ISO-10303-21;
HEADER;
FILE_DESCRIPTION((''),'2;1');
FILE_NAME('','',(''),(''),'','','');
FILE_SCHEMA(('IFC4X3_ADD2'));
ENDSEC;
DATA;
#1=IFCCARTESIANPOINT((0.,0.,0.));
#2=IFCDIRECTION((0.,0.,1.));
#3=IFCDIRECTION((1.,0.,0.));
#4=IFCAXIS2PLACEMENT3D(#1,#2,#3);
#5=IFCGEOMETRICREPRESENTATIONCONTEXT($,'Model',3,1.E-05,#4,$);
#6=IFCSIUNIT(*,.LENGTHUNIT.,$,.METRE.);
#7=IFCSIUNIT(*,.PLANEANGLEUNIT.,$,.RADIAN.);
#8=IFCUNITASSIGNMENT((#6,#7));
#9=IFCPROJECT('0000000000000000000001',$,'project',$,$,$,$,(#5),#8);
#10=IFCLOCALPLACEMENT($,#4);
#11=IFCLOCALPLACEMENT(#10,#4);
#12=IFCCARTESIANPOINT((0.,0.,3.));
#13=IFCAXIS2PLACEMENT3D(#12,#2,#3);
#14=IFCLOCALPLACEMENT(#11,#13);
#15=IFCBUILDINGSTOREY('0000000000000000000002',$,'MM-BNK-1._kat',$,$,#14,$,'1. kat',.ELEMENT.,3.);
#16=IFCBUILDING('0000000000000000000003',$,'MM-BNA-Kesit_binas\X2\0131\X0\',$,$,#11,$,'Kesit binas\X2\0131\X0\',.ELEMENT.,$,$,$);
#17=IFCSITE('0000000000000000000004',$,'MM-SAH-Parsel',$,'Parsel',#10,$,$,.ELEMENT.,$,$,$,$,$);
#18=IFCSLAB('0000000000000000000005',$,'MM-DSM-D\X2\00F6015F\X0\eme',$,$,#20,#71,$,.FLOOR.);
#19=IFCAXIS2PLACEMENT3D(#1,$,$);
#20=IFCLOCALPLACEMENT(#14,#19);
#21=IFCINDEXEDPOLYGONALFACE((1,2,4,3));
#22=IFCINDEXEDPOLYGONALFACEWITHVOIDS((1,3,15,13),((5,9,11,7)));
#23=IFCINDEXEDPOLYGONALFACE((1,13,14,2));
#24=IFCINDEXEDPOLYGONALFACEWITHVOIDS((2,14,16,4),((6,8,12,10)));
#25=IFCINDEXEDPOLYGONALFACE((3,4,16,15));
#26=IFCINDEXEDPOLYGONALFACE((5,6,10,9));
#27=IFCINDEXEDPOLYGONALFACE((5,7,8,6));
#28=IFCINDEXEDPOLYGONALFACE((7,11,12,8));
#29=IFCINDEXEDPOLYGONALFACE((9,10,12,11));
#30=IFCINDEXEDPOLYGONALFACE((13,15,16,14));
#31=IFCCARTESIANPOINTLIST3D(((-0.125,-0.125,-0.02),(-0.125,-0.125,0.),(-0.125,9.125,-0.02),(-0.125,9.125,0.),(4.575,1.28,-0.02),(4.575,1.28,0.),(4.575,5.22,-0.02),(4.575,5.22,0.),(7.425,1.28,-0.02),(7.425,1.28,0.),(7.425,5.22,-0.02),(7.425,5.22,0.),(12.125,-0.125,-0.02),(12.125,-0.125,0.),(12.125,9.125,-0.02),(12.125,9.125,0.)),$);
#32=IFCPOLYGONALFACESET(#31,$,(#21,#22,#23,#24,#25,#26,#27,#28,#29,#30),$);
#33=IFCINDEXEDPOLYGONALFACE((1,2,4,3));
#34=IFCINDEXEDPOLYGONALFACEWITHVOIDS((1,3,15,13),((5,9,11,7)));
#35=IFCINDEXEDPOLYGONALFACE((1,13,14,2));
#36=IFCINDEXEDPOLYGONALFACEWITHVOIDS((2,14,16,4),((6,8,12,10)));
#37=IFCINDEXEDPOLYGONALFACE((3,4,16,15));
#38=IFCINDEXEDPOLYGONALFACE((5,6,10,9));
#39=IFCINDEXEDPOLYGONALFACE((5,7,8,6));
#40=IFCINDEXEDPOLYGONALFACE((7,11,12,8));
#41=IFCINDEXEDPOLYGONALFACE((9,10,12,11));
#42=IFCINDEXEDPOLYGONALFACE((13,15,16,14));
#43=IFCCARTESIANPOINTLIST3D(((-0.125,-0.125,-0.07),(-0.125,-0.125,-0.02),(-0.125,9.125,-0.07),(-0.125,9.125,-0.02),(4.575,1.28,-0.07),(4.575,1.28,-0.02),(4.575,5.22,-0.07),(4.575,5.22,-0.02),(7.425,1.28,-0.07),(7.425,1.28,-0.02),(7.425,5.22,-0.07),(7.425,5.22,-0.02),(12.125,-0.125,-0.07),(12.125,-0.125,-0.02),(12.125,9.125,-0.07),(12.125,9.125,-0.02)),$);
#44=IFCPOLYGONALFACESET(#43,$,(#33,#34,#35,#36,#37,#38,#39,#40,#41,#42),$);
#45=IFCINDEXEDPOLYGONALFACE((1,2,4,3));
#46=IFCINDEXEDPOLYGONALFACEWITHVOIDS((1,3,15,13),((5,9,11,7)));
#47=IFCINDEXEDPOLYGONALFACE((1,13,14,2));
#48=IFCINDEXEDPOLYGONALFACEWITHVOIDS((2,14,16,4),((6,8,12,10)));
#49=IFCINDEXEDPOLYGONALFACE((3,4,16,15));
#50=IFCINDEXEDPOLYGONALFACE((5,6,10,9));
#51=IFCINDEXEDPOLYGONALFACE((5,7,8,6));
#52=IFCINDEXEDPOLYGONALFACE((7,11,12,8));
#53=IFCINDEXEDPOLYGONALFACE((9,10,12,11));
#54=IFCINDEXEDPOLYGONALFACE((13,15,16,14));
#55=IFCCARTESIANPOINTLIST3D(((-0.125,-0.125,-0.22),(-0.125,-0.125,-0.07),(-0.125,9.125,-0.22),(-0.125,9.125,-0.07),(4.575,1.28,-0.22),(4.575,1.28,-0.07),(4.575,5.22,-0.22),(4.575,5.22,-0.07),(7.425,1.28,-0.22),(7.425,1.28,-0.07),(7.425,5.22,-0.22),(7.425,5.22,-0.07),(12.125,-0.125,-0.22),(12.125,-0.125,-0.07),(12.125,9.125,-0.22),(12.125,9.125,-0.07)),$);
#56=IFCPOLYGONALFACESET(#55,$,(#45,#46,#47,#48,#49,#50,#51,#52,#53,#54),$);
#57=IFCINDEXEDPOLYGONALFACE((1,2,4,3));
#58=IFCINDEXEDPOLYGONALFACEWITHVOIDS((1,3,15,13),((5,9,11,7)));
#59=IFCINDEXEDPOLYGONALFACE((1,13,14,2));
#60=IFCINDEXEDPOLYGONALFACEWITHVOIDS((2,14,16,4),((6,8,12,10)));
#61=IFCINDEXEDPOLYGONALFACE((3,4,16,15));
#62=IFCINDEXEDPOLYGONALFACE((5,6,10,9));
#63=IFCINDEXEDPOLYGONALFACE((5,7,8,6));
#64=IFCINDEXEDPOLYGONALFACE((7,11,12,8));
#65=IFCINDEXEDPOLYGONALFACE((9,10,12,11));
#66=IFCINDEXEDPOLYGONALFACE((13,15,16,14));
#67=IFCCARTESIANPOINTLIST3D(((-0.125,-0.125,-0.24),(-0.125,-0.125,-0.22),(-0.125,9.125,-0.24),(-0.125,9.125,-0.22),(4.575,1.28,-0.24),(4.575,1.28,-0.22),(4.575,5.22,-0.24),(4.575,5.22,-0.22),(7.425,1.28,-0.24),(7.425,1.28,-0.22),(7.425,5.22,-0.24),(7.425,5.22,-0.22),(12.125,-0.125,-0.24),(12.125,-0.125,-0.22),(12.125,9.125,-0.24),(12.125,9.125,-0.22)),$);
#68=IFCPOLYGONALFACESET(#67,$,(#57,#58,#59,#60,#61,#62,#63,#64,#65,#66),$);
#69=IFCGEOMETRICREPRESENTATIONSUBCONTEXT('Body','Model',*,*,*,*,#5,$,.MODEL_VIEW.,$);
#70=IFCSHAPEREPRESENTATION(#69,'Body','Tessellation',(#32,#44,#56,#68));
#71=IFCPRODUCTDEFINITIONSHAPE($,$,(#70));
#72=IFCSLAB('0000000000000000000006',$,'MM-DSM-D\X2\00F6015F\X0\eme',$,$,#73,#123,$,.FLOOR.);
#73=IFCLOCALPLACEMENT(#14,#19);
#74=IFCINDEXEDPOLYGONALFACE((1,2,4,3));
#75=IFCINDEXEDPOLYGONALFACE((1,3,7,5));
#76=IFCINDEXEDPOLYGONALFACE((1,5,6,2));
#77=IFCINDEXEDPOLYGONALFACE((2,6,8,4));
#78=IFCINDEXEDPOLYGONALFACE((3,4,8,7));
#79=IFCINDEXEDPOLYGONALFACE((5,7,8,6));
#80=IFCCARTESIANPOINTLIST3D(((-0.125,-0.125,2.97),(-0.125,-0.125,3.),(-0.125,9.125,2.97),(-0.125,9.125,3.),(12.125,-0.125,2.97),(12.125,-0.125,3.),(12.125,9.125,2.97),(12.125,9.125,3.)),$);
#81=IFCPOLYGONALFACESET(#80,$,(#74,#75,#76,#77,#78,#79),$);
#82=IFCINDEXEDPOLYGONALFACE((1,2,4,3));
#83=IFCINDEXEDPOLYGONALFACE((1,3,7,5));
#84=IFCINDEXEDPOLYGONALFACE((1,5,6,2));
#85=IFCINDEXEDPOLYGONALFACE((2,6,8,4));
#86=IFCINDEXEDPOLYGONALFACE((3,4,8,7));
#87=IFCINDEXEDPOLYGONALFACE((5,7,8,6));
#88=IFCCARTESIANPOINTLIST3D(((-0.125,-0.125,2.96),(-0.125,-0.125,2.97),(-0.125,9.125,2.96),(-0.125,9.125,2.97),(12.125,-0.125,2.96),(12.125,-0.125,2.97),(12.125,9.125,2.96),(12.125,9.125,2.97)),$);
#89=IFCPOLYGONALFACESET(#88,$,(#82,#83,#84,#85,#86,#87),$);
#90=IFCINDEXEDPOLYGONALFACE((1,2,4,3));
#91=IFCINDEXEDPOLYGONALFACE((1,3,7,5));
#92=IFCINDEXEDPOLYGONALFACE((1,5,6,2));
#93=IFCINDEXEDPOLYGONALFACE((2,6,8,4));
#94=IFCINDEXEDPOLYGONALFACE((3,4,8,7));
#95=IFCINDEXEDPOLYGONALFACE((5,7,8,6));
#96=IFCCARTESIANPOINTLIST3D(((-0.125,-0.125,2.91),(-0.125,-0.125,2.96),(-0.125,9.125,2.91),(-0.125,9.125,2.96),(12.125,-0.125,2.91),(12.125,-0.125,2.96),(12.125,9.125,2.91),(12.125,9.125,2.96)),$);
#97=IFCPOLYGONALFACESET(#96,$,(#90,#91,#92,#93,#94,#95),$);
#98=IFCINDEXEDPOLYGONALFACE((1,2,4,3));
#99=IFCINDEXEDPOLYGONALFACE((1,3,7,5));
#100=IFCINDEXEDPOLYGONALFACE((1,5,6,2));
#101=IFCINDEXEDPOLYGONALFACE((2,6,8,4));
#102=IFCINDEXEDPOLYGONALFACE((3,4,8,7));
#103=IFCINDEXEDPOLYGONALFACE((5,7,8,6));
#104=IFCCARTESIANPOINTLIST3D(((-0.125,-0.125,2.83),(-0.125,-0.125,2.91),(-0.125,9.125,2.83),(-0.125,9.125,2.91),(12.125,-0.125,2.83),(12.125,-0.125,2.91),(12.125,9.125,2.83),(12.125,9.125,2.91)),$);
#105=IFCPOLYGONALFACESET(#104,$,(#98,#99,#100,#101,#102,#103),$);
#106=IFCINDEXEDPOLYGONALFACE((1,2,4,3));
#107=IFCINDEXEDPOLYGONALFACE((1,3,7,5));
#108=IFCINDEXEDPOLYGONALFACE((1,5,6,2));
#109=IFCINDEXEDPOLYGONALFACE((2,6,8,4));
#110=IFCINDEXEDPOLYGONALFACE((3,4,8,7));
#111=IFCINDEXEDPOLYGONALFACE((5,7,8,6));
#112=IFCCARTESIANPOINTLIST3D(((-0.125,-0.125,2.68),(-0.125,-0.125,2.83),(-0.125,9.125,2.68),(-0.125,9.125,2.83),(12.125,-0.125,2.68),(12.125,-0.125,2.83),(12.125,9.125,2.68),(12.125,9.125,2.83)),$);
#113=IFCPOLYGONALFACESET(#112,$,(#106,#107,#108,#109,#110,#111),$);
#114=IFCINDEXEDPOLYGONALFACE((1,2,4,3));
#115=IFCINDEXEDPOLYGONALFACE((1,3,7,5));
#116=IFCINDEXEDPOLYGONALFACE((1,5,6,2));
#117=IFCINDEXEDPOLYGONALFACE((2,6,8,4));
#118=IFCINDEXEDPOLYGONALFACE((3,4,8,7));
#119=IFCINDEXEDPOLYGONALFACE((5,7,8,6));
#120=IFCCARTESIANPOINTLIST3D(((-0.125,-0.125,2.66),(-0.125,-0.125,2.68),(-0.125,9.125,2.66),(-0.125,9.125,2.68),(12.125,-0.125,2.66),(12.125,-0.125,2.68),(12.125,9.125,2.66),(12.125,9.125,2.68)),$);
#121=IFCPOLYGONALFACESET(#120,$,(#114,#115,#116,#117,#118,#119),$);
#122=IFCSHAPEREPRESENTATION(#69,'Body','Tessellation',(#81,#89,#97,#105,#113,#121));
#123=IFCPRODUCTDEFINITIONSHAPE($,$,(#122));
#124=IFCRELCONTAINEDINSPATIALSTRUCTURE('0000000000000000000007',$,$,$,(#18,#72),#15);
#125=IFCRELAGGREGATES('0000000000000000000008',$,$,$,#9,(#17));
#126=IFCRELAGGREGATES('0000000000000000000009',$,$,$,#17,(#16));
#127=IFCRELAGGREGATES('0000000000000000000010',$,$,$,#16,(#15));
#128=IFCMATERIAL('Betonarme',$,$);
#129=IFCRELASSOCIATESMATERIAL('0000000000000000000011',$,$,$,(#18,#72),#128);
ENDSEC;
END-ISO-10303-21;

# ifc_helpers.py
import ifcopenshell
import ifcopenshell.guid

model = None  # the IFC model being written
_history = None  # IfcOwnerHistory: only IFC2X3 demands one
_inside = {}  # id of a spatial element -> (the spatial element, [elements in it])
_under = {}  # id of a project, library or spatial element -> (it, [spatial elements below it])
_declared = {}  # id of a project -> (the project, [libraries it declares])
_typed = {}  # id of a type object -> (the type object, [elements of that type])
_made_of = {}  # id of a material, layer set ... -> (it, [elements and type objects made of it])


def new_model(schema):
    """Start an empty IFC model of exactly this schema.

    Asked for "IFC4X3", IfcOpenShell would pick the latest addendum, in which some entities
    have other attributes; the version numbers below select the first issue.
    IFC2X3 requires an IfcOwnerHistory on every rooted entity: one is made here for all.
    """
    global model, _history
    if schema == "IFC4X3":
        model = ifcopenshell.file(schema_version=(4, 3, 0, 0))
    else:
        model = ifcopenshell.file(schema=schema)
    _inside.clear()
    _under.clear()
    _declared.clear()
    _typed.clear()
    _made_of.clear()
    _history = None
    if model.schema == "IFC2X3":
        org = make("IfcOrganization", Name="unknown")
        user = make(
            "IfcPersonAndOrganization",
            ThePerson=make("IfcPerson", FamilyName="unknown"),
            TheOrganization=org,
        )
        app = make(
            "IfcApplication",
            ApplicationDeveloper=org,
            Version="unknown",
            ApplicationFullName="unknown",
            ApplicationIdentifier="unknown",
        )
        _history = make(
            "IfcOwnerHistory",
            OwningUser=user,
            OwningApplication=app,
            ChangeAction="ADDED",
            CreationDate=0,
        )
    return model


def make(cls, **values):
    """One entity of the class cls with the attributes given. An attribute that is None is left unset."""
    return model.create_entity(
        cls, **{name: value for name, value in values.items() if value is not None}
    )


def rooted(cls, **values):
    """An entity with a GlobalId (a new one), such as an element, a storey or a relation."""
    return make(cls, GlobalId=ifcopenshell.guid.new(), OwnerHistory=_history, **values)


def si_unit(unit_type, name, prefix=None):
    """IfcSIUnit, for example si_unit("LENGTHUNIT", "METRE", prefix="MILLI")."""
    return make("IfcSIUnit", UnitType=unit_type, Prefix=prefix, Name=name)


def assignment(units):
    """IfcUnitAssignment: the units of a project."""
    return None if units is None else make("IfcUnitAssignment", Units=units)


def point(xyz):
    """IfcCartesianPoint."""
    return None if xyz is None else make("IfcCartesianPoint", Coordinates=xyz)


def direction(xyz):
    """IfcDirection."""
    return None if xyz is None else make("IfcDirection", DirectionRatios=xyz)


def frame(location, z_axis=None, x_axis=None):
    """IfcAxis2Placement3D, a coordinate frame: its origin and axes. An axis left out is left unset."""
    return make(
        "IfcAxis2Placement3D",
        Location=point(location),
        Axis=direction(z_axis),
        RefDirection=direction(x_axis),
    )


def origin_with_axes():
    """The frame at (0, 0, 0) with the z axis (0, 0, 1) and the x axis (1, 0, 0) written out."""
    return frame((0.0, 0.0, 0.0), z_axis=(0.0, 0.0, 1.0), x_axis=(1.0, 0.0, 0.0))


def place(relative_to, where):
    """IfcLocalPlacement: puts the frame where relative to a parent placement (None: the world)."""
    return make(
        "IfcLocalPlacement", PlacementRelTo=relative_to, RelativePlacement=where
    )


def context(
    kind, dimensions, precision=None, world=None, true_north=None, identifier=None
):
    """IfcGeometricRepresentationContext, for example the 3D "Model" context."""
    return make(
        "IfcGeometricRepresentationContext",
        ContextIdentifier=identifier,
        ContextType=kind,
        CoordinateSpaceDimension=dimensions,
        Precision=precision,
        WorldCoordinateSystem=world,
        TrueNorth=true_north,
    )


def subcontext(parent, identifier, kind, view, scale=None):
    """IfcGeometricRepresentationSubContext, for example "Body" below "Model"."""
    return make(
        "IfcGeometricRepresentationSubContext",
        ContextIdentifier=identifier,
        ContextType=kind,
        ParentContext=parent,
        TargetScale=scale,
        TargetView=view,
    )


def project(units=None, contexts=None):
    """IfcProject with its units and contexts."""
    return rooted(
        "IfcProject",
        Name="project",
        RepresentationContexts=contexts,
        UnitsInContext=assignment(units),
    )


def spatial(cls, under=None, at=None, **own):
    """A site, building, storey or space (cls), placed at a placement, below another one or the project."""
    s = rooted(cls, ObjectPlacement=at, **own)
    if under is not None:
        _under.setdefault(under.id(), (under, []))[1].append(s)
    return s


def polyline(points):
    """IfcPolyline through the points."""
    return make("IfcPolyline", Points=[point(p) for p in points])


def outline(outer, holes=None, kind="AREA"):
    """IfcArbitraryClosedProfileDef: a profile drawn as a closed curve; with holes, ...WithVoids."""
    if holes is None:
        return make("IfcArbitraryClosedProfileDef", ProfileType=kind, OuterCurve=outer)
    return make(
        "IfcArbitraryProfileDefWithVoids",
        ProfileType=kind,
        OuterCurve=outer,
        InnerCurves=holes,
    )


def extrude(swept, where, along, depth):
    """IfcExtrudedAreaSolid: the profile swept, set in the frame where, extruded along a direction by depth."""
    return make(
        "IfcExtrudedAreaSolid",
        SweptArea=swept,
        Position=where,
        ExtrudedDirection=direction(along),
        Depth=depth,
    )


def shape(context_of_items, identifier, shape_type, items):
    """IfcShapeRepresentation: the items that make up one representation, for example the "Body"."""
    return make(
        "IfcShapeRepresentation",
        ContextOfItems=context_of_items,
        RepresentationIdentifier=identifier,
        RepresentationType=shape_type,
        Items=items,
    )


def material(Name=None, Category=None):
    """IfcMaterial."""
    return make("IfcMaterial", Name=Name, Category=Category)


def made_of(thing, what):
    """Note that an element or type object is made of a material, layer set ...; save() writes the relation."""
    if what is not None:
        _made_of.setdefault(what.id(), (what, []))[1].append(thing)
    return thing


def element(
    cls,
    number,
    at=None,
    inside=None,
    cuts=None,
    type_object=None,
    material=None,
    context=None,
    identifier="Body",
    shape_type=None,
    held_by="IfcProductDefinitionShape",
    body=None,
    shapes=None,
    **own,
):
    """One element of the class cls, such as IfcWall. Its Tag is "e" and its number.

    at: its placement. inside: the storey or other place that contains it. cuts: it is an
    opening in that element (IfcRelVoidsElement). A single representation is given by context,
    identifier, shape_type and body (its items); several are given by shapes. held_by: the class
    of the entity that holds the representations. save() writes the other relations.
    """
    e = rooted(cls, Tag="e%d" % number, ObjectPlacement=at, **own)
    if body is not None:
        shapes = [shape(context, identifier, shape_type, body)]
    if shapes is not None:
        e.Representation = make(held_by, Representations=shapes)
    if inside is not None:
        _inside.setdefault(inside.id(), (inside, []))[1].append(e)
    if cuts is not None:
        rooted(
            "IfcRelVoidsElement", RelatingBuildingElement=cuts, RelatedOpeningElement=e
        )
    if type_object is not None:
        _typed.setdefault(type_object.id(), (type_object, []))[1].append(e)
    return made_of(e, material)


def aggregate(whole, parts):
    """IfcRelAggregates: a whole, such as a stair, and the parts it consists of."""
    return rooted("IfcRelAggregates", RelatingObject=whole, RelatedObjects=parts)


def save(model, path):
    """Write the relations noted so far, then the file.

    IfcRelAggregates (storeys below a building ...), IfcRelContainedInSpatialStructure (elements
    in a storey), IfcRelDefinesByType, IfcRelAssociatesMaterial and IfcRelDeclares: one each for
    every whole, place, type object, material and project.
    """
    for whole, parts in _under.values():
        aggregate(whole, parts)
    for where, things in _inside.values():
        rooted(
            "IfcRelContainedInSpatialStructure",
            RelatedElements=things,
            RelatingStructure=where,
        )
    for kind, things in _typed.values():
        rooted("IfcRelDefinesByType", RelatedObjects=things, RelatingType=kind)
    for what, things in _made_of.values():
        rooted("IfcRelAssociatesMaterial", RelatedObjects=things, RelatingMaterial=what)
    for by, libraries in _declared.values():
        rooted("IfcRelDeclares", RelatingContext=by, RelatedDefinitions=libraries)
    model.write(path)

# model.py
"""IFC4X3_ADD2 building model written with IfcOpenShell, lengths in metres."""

from ifc_helpers import new_model, si_unit, frame, origin_with_axes, place, context, subcontext, project, spatial, polyline, outline, extrude, material, element, save


model = new_model("IFC4X3_ADD2")

# Units and contexts
model_context = context("Model", 3, precision=1e-05, world=origin_with_axes())
body_context = subcontext(model_context, "Body", "Model", "MODEL_VIEW")
ifc_project = project(units=[si_unit("LENGTHUNIT", "METRE"), si_unit("PLANEANGLEUNIT", "RADIAN")], contexts=[model_context])

# Site, building, storey
site_placement = place(None, origin_with_axes())
site = spatial("IfcSite", under=ifc_project, at=site_placement, Name="MM-SAH-Parsel", ObjectType="Parsel", CompositionType="ELEMENT")
building_placement = place(site_placement, origin_with_axes())
building = spatial("IfcBuilding", under=site, at=building_placement, Name="MM-BNA-Kesit_binası", LongName="Kesit binası", CompositionType="ELEMENT")
storey_placement = place(building_placement, frame((0.0, 0.0, 3.0), z_axis=(0.0, 0.0, 1.0), x_axis=(1.0, 0.0, 0.0)))
storey = spatial("IfcBuildingStorey", under=building, at=storey_placement, Name="MM-BNK-1._kat", LongName="1. kat", CompositionType="ELEMENT", Elevation=3.0)

# Shared definitions
ifc_material_1 = material(Name="Betonarme")

# Slab, opening
slab_1_placement = place(storey_placement, origin_with_axes())
slab_1 = element("IfcSlab", 1, at=slab_1_placement, inside=storey, material=ifc_material_1, Name="MM-DSM-Döşeme", PredefinedType="FLOOR", context=body_context, shape_type="SweptSolid", body=[
    extrude(outline(polyline([(-0.125, -0.125), (12.125, -0.125), (12.125, 9.125), (-0.125, 9.125), (-0.125, -0.125)])), frame((0.0, 0.0, -0.02)), (0.0, 0.0, 1.0), 0.02),
    extrude(outline(polyline([(-0.125, -0.125), (12.125, -0.125), (12.125, 9.125), (-0.125, 9.125), (-0.125, -0.125)])), frame((0.0, 0.0, -0.07)), (0.0, 0.0, 1.0), 0.05),
    extrude(outline(polyline([(-0.125, -0.125), (12.125, -0.125), (12.125, 9.125), (-0.125, 9.125), (-0.125, -0.125)])), frame((0.0, 0.0, -0.22)), (0.0, 0.0, 1.0), 0.15),
    extrude(outline(polyline([(-0.125, -0.125), (12.125, -0.125), (12.125, 9.125), (-0.125, 9.125), (-0.125, -0.125)])), frame((0.0, 0.0, -0.24)), (0.0, 0.0, 1.0), 0.02),
])
opening_1_placement = place(storey_placement, origin_with_axes())
element("IfcOpeningElement", 2, at=opening_1_placement, cuts=slab_1, PredefinedType="OPENING", context=body_context, shape_type="SweptSolid", body=[
    extrude(outline(polyline([(4.575, 1.28), (4.575, 5.22), (7.425, 5.22), (7.425, 1.28), (4.575, 1.28)])), frame((0.0, 0.0, -0.24)), (0.0, 0.0, 1.0), 0.24),
])

# Slab
slab_2_placement = place(storey_placement, origin_with_axes())
element("IfcSlab", 3, at=slab_2_placement, inside=storey, material=ifc_material_1, Name="MM-DSM-Döşeme", PredefinedType="FLOOR", context=body_context, shape_type="SweptSolid", body=[
    extrude(outline(polyline([(-0.125, -0.125), (12.125, -0.125), (12.125, 9.125), (-0.125, 9.125), (-0.125, -0.125)])), frame((0.0, 0.0, 2.97)), (0.0, 0.0, 1.0), 0.03),
    extrude(outline(polyline([(-0.125, -0.125), (12.125, -0.125), (12.125, 9.125), (-0.125, 9.125), (-0.125, -0.125)])), frame((0.0, 0.0, 2.96)), (0.0, 0.0, 1.0), 0.01),
    extrude(outline(polyline([(-0.125, -0.125), (12.125, -0.125), (12.125, 9.125), (-0.125, 9.125), (-0.125, -0.125)])), frame((0.0, 0.0, 2.91)), (0.0, 0.0, 1.0), 0.05),
    extrude(outline(polyline([(-0.125, -0.125), (12.125, -0.125), (12.125, 9.125), (-0.125, 9.125), (-0.125, -0.125)])), frame((0.0, 0.0, 2.83)), (0.0, 0.0, 1.0), 0.08),
    extrude(outline(polyline([(-0.125, -0.125), (12.125, -0.125), (12.125, 9.125), (-0.125, 9.125), (-0.125, -0.125)])), frame((0.0, 0.0, 2.68)), (0.0, 0.0, 1.0), 0.15),
    extrude(outline(polyline([(-0.125, -0.125), (12.125, -0.125), (12.125, 9.125), (-0.125, 9.125), (-0.125, -0.125)])), frame((0.0, 0.0, 2.66)), (0.0, 0.0, 1.0), 0.02),
])

save(model, "model.ifc")
